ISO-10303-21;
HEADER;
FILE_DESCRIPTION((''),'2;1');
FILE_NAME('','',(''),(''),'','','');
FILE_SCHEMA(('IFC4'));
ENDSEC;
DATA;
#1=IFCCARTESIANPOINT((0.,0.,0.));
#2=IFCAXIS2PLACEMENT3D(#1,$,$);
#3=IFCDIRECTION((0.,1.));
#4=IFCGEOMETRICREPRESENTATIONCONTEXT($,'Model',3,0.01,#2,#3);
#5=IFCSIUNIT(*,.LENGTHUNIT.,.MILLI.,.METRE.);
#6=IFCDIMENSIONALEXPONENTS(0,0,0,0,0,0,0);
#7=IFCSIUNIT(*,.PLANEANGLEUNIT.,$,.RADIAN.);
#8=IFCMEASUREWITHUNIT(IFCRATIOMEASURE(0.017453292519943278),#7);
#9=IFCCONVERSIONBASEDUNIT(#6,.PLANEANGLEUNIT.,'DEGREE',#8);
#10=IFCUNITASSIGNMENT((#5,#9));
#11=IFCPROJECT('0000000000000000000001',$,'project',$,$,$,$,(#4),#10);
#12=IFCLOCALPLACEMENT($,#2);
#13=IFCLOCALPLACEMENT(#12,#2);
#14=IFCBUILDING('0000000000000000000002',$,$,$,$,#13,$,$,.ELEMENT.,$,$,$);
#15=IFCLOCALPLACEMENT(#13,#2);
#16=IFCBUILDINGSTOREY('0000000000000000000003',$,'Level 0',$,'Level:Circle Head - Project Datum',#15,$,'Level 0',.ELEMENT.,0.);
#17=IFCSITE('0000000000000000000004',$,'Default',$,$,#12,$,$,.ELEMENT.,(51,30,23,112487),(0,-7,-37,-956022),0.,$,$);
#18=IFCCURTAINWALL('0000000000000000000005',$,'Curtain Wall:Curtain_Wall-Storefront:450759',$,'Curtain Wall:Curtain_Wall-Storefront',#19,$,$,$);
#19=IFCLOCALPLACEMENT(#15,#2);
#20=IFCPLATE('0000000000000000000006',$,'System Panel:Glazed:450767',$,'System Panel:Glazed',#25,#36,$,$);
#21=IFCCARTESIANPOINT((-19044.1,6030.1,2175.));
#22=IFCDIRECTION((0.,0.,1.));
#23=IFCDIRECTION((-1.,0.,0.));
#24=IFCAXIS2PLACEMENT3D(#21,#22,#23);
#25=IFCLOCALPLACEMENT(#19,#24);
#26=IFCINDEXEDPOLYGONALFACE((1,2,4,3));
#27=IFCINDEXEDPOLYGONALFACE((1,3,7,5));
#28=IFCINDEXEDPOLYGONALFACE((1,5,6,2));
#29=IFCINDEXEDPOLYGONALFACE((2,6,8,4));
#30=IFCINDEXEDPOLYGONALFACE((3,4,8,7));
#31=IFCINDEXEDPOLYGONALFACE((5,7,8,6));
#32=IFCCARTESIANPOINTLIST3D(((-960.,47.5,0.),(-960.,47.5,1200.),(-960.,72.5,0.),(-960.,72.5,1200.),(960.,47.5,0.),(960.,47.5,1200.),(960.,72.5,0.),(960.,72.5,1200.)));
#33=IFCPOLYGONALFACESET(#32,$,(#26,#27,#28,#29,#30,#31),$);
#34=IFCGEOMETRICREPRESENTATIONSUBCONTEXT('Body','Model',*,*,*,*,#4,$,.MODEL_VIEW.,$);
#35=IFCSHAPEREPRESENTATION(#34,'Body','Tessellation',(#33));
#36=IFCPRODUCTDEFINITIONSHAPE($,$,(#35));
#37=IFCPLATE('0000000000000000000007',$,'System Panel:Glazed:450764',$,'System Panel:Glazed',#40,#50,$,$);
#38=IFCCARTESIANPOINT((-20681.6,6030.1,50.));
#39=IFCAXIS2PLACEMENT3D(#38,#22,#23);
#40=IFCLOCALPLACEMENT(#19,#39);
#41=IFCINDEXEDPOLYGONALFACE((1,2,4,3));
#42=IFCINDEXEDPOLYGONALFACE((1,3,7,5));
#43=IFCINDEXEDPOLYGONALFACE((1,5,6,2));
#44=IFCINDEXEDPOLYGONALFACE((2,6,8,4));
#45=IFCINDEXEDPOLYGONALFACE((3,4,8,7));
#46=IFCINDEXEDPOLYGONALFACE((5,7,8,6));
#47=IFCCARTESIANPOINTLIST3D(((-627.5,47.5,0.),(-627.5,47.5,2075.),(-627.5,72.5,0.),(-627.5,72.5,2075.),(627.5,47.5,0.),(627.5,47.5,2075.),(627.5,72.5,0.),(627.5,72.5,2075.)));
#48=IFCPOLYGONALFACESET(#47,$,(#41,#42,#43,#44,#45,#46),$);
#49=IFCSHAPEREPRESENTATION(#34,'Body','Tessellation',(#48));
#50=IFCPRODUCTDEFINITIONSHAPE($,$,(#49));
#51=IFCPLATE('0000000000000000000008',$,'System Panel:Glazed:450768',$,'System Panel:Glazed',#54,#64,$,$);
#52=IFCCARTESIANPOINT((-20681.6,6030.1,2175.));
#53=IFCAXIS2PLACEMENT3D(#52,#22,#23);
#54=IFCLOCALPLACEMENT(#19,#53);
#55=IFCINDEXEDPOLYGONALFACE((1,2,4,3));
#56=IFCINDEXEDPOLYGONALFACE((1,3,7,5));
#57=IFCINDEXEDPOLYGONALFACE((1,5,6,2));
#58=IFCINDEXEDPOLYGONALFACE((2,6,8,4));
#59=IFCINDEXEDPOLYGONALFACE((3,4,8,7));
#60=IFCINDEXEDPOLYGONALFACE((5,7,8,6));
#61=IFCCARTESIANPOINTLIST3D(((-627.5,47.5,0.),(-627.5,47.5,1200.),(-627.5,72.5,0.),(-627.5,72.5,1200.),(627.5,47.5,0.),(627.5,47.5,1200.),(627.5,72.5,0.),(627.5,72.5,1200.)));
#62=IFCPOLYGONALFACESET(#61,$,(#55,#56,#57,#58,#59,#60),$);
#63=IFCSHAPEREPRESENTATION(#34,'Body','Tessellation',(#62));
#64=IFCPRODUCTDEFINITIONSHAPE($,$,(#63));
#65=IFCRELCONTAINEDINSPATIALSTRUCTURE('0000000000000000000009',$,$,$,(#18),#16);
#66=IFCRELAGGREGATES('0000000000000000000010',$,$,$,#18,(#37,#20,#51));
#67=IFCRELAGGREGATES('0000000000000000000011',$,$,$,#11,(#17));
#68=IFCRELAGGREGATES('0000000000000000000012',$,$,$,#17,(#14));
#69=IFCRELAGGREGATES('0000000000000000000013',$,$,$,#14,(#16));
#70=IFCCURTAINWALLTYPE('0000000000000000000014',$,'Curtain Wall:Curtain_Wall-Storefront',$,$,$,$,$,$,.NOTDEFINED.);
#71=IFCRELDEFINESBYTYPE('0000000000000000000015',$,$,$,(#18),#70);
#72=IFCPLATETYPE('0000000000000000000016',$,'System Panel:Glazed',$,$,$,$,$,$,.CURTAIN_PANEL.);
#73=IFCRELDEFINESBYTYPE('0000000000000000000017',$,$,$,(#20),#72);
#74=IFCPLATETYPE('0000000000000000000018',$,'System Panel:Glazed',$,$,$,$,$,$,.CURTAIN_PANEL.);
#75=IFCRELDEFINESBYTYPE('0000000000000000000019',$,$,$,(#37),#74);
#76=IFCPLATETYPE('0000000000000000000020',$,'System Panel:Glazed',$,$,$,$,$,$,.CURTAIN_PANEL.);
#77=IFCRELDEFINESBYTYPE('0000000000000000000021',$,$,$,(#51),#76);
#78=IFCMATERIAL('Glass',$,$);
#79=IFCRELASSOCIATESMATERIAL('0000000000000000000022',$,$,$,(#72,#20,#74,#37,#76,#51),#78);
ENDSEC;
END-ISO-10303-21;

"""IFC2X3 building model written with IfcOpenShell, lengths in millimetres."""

from ifc_helpers import new_model, entity, si_unit, converted_unit, direction, frame, origin, origin_2d_with_axis, place, context, subcontext, project, spatial, rectangle, extrude, source, transform, mapped, material, type_object, type_shapes, element, aggregate, save


model = new_model("IFC2X3")

# Units and contexts
model_context = context("Model", 3, precision=0.01, world=origin(), true_north=direction((0.0, 1.0)))
body_context = subcontext(model_context, "Body", "Model", "MODEL_VIEW")
ifc_project = project(units=[si_unit("LENGTHUNIT", "METRE", prefix="MILLI"), converted_unit("PLANEANGLEUNIT", "DEGREE", entity("IfcRatioMeasure", 0.017453292519943278), si_unit("PLANEANGLEUNIT", "RADIAN"), dimensions=[0, 0, 0, 0, 0, 0, 0])], contexts=[model_context])

# Site, building, storey
site_placement = place(None, origin())
site = spatial("IfcSite", under=ifc_project, at=site_placement, Name="Default", CompositionType="ELEMENT", RefLatitude=(51, 30, 23, 112487), RefLongitude=(0, -7, -37, -956022), RefElevation=0.0)
building_placement = place(site_placement, origin())
building = spatial("IfcBuilding", under=site, at=building_placement, CompositionType="ELEMENT")
storey_placement = place(building_placement, origin())
storey = spatial("IfcBuildingStorey", under=building, at=storey_placement, Name="Level 0", ObjectType="Level:Circle Head - Project Datum", LongName="Level 0", CompositionType="ELEMENT", Elevation=0.0)

# Curtain wall, plates
curtain_wall_type = type_object("IfcCurtainWallType", Name="Curtain Wall:Curtain_Wall-Storefront", PredefinedType="NOTDEFINED")
curtain_wall_placement = place(storey_placement, origin())
curtain_wall = element("IfcCurtainWall", 1, at=curtain_wall_placement, inside=storey, type_object=curtain_wall_type, Name="Curtain Wall:Curtain_Wall-Storefront:450759", ObjectType="Curtain Wall:Curtain_Wall-Storefront")
ifc_material_1 = material(Name="Glass")
plate_type_1 = type_object("IfcPlateType", Name="System Panel:Glazed", PredefinedType="CURTAIN_PANEL", material=ifc_material_1)
shared_shape_1 = source(origin(), body_context, "Body", "SweptSolid", [
    extrude(rectangle(XDim=25.0, YDim=1920.0, at=origin_2d_with_axis()), frame((0.0, 60.0, 0.0), z_axis=(0.0, 0.0, 1.0), x_axis=(0.0, 1.0, 0.0)), (0.0, 0.0, 1.0), 1200.0),
])
type_shapes(plate_type_1, [shared_shape_1])
plate_1_placement = place(curtain_wall_placement, frame((-19044.1, 6030.1, 2175.0), z_axis=(0.0, 0.0, 1.0), x_axis=(-1.0, 0.0, 0.0)))
plate_1 = element("IfcPlate", 2, at=plate_1_placement, type_object=plate_type_1, material=ifc_material_1, Name="System Panel:Glazed:450767", ObjectType="System Panel:Glazed", context=body_context, shape_type="MappedRepresentation", body=[
    mapped(shared_shape_1, transform((0.0, 0.0, 0.0), scale=1.0)),
])
plate_type_2 = type_object("IfcPlateType", Name="System Panel:Glazed", PredefinedType="CURTAIN_PANEL", material=ifc_material_1)
shared_shape_2 = source(origin(), body_context, "Body", "SweptSolid", [
    extrude(rectangle(XDim=25.0, YDim=1255.0, at=origin_2d_with_axis()), frame((0.0, 60.0, 0.0), z_axis=(0.0, 0.0, 1.0), x_axis=(0.0, 1.0, 0.0)), (0.0, 0.0, 1.0), 2075.0),
])
type_shapes(plate_type_2, [shared_shape_2])
plate_2_placement = place(curtain_wall_placement, frame((-20681.6, 6030.1, 50.0), z_axis=(0.0, 0.0, 1.0), x_axis=(-1.0, 0.0, 0.0)))
plate_2 = element("IfcPlate", 3, at=plate_2_placement, type_object=plate_type_2, material=ifc_material_1, Name="System Panel:Glazed:450764", ObjectType="System Panel:Glazed", context=body_context, shape_type="MappedRepresentation", body=[
    mapped(shared_shape_2, transform((0.0, 0.0, 0.0), scale=1.0)),
])
plate_type_3 = type_object("IfcPlateType", Name="System Panel:Glazed", PredefinedType="CURTAIN_PANEL", material=ifc_material_1)
shared_shape_3 = source(origin(), body_context, "Body", "SweptSolid", [
    extrude(rectangle(XDim=25.0, YDim=1255.0, at=origin_2d_with_axis()), frame((0.0, 60.0, 0.0), z_axis=(0.0, 0.0, 1.0), x_axis=(0.0, 1.0, 0.0)), (0.0, 0.0, 1.0), 1200.0),
])
type_shapes(plate_type_3, [shared_shape_3])
plate_3_placement = place(curtain_wall_placement, frame((-20681.6, 6030.1, 2175.0), z_axis=(0.0, 0.0, 1.0), x_axis=(-1.0, 0.0, 0.0)))
plate_3 = element("IfcPlate", 4, at=plate_3_placement, type_object=plate_type_3, material=ifc_material_1, Name="System Panel:Glazed:450768", ObjectType="System Panel:Glazed", context=body_context, shape_type="MappedRepresentation", body=[
    mapped(shared_shape_3, transform((0.0, 0.0, 0.0), scale=1.0)),
])
aggregate(curtain_wall, [plate_2, plate_1, plate_3])

save(model, "model.ifc")
